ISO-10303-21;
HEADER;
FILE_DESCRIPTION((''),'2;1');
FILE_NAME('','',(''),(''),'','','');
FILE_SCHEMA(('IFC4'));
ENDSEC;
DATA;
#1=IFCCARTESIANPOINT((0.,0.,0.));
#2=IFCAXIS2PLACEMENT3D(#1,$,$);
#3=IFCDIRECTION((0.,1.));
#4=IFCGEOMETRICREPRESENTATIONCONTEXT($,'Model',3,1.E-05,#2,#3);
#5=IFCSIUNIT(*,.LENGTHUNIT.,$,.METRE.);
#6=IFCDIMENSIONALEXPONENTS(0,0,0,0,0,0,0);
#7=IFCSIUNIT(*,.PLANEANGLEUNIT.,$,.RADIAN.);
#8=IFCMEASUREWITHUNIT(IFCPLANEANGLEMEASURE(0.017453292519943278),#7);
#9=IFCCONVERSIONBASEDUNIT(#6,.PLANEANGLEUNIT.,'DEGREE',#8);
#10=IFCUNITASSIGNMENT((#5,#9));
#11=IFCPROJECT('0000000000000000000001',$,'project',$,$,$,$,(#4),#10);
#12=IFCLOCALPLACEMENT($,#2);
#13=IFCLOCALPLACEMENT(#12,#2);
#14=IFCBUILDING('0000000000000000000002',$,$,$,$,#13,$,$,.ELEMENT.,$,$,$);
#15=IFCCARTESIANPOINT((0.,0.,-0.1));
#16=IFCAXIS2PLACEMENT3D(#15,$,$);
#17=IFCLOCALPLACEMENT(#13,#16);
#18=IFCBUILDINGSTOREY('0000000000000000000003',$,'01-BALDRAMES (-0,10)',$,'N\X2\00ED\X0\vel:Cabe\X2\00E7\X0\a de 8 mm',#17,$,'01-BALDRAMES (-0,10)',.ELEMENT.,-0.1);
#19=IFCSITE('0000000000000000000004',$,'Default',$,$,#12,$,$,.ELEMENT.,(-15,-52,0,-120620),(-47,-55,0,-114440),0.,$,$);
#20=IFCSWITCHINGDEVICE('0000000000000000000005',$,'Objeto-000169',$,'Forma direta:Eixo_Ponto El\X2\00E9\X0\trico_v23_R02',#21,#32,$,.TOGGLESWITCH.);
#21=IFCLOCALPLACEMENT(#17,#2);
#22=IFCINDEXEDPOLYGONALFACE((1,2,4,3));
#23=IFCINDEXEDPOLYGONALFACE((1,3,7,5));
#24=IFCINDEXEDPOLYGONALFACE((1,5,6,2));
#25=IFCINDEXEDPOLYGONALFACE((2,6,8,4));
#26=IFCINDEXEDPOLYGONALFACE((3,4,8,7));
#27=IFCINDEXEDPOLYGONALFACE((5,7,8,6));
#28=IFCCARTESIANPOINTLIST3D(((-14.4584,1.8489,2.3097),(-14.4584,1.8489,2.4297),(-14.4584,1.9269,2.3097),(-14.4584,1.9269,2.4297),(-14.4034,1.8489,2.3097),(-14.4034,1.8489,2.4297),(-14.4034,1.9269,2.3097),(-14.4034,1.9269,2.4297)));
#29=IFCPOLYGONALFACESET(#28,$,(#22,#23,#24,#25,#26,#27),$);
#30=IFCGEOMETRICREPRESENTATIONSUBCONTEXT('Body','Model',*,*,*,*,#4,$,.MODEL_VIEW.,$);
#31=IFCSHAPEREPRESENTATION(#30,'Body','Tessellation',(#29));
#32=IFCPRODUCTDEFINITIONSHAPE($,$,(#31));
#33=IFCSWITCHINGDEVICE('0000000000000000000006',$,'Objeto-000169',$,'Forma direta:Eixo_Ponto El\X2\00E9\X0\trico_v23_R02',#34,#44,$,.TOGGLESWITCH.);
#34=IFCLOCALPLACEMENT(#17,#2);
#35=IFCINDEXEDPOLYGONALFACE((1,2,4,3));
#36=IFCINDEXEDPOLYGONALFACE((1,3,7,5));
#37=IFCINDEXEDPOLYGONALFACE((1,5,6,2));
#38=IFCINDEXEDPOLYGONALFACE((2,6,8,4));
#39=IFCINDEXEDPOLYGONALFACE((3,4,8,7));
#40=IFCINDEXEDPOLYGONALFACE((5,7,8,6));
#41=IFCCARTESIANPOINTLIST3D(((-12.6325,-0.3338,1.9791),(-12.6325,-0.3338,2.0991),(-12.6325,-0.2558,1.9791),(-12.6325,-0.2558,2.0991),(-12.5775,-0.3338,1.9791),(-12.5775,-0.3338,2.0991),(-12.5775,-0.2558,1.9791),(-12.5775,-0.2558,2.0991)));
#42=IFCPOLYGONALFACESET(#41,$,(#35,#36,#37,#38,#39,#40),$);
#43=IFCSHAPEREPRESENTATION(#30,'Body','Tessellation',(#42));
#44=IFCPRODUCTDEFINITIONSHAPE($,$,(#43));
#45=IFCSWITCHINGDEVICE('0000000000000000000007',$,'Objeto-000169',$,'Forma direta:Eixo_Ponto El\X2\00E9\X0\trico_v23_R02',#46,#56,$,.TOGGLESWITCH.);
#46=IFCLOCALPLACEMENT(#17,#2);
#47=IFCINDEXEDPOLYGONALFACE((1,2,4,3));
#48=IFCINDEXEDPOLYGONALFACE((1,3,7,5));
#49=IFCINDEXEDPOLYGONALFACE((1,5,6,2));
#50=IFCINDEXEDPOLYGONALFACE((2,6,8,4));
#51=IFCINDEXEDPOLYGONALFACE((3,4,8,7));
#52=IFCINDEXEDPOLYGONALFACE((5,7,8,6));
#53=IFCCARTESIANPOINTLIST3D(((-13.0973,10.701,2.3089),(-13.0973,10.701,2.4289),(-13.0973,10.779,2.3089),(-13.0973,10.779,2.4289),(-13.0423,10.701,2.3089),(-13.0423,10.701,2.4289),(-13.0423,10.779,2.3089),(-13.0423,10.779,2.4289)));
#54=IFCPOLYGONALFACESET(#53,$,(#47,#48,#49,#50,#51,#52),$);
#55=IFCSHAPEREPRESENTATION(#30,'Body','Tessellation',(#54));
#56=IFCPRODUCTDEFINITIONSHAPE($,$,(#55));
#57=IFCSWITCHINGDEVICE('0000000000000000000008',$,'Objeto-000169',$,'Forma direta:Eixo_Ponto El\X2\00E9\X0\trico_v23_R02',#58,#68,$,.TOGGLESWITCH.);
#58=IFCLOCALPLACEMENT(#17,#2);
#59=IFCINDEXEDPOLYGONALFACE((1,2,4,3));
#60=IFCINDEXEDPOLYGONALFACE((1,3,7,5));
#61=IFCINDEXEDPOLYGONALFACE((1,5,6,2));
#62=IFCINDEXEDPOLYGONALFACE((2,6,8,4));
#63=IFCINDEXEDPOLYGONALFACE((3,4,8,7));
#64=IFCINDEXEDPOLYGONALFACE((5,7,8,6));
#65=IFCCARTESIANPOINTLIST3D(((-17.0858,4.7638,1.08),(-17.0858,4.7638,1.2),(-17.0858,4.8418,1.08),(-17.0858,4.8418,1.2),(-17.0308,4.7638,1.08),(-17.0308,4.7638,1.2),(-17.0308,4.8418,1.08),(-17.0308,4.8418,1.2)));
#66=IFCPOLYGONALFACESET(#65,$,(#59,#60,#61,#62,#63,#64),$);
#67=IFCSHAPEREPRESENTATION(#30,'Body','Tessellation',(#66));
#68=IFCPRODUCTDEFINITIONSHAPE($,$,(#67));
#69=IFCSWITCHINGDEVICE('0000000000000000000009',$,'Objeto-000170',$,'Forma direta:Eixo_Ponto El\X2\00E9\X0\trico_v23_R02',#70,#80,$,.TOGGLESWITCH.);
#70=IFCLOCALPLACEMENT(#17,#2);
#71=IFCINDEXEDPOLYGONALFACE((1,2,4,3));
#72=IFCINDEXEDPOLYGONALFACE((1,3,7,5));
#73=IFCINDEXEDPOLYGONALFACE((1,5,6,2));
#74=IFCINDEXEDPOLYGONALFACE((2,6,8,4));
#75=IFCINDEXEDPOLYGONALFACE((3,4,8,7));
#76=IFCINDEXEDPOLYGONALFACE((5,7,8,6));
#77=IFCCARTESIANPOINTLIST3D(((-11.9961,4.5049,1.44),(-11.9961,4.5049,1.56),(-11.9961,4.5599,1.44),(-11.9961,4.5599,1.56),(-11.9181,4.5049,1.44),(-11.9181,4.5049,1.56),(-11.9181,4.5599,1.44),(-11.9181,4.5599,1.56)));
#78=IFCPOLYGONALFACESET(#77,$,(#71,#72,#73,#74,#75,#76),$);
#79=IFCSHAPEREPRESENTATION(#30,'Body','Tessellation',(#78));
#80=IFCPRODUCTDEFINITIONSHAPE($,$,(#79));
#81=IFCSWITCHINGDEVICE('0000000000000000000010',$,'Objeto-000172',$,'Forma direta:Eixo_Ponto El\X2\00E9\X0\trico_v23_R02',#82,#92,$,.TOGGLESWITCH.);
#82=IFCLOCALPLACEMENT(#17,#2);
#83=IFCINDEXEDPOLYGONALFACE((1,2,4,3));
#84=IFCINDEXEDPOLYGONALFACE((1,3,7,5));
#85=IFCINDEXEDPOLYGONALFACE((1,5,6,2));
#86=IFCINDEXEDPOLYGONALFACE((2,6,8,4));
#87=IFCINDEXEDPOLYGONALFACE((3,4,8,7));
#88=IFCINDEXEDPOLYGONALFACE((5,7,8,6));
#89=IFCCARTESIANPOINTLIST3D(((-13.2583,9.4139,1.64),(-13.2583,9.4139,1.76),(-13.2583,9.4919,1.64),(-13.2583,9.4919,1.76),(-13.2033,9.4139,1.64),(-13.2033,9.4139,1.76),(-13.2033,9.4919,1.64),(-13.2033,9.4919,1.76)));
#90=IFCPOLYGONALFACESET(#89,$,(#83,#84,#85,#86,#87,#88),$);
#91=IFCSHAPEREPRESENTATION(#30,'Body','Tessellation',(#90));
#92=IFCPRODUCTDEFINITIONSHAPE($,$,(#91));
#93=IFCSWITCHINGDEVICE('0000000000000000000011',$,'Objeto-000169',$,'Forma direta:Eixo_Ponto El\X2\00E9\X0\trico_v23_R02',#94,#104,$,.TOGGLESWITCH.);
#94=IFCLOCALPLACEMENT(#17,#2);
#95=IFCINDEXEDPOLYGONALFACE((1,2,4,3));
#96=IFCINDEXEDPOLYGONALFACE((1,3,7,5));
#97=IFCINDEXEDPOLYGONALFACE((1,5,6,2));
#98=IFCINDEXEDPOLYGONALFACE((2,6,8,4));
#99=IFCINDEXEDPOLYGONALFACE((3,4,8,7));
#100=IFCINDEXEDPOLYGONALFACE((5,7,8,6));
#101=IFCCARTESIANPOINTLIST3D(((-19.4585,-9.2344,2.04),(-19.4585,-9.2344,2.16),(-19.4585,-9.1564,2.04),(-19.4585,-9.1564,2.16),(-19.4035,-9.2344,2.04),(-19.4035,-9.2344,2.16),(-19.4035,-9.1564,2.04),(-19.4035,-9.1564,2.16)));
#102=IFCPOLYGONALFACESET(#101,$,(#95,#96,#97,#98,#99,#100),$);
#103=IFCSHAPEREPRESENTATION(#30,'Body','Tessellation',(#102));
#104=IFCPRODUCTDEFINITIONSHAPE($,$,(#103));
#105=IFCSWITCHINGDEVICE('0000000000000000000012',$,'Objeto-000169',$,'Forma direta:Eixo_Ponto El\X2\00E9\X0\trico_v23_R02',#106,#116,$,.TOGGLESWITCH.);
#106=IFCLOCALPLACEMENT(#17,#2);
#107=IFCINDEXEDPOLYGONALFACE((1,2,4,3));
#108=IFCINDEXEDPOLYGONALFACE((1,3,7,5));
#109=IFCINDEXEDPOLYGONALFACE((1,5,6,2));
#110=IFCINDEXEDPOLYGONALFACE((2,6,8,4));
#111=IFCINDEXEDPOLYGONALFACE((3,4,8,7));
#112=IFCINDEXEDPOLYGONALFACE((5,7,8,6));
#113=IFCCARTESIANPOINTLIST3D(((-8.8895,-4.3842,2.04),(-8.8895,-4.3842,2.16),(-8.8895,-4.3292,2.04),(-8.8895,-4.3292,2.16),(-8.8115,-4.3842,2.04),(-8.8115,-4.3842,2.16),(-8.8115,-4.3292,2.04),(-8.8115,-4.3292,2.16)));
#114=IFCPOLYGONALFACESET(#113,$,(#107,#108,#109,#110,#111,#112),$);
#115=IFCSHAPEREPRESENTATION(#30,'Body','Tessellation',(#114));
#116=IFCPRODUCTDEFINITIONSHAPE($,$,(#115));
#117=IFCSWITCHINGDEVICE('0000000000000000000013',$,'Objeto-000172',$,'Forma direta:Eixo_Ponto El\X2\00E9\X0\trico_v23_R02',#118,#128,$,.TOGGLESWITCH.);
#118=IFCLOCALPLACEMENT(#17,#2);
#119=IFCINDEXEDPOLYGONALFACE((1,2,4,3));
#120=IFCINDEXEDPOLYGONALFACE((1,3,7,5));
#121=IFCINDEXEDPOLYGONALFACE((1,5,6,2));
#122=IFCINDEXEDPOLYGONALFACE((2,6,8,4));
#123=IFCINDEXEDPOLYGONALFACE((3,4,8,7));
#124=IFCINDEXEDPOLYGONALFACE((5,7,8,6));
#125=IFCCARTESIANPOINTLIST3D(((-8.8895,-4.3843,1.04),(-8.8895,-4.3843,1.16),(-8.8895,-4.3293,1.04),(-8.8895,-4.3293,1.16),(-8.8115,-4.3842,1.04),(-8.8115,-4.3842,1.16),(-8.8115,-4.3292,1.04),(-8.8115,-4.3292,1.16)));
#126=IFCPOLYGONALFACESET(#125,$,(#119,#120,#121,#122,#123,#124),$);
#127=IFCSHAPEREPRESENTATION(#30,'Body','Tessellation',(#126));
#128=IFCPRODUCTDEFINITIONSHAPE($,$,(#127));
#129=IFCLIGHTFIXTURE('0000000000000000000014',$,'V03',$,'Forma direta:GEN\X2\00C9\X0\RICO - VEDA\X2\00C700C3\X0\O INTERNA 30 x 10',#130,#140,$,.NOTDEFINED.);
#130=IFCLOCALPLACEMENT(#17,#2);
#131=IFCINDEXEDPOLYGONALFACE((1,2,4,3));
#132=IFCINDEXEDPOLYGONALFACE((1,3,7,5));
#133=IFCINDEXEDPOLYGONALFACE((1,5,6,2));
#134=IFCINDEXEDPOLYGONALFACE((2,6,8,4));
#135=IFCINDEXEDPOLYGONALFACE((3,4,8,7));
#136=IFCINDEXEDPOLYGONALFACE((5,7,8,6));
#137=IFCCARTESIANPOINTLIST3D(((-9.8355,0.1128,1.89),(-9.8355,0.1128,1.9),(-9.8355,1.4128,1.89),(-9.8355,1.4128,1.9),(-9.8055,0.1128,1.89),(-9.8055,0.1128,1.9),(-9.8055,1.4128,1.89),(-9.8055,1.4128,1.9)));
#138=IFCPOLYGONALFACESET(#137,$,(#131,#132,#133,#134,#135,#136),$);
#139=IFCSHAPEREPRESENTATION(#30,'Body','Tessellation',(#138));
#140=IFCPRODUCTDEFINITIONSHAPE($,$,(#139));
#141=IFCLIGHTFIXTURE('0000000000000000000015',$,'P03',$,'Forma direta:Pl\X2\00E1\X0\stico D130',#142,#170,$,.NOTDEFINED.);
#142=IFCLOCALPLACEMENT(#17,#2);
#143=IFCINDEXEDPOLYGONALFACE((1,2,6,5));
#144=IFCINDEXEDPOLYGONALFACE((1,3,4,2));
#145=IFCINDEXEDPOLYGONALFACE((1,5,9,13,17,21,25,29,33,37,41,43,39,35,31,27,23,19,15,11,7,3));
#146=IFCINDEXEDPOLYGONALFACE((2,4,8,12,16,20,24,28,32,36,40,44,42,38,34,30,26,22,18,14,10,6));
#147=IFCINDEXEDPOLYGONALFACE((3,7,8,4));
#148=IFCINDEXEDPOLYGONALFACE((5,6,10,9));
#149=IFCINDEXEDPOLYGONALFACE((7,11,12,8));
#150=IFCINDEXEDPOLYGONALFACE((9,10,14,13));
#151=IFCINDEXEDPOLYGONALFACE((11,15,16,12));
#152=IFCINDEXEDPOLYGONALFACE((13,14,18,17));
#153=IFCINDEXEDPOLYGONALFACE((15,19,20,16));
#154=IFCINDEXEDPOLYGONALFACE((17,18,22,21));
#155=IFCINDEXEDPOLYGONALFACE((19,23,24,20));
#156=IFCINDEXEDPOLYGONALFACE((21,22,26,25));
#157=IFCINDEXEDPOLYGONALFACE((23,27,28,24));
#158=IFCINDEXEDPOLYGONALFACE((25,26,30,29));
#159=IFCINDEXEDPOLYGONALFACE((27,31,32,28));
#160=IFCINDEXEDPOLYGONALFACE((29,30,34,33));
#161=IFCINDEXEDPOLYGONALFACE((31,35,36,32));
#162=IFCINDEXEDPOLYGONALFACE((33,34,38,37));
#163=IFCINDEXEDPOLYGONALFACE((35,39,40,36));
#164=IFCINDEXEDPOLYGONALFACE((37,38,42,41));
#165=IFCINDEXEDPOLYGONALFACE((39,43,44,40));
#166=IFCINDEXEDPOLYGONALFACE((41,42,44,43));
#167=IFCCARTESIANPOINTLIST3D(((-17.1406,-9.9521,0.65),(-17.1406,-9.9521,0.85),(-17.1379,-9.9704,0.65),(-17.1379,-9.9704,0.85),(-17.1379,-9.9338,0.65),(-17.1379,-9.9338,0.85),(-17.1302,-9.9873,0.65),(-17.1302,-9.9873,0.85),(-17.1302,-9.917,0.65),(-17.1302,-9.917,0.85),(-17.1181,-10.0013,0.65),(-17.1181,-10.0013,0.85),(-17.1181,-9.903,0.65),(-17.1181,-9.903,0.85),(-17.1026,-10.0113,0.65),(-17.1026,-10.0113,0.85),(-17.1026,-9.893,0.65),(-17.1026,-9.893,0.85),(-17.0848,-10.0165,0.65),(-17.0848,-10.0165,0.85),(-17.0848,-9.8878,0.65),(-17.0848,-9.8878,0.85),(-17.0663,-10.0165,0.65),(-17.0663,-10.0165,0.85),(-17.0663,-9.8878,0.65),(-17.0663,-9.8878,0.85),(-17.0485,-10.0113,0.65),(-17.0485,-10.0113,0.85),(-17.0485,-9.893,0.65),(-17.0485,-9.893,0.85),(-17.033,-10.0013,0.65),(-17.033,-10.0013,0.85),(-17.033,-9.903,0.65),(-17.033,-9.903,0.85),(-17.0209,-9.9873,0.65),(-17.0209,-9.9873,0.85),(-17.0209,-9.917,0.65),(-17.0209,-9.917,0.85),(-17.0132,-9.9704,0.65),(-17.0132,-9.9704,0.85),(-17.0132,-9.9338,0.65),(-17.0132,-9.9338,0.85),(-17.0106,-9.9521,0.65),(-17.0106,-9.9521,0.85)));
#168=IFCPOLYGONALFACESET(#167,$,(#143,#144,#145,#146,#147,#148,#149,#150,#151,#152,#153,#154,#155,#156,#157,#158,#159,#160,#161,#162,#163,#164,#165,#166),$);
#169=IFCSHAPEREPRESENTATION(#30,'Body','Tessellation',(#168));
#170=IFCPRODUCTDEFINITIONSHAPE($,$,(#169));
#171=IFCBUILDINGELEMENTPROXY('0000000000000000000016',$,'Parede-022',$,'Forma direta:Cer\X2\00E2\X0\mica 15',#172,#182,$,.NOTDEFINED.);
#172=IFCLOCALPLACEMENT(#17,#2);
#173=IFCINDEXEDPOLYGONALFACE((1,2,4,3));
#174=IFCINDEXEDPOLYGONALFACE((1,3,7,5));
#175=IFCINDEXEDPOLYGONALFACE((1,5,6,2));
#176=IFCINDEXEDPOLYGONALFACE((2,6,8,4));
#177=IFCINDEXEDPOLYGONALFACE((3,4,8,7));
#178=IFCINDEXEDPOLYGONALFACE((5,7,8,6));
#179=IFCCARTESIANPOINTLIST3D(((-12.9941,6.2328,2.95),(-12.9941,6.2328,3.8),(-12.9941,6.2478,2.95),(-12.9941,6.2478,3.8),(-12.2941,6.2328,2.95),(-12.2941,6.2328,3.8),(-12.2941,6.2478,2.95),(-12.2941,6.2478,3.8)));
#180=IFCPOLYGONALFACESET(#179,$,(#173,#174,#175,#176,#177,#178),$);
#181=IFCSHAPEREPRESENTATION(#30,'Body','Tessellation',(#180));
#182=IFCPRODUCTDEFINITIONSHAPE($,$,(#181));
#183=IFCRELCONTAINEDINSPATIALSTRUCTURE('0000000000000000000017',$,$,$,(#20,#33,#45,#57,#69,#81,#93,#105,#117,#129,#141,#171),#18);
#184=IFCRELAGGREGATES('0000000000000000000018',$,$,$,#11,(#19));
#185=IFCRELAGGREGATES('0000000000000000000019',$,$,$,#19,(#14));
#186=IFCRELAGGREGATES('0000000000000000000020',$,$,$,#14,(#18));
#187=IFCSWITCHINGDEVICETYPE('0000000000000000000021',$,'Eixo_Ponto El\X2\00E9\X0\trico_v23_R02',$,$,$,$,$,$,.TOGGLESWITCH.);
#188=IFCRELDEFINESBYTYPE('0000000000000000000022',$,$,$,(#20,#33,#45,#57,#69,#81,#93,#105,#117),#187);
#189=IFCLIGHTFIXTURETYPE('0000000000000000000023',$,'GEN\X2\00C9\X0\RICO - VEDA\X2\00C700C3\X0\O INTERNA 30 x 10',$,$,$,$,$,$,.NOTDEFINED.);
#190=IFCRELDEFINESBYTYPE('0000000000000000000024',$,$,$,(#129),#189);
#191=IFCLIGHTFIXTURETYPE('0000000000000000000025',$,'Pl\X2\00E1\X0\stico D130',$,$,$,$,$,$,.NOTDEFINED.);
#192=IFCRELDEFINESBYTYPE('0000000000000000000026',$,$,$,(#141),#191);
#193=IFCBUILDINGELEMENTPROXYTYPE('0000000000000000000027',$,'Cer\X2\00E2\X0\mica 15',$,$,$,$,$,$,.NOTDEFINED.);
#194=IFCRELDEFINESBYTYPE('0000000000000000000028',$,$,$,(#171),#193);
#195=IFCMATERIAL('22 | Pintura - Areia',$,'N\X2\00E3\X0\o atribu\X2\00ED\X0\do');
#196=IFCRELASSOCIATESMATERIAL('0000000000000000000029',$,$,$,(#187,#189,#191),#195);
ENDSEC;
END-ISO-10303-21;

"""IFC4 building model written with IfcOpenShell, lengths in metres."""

from ifc_helpers import new_model, entity, si_unit, converted_unit, direction, frame, origin, place, context, subcontext, project, spatial, arc, indexed_curve, outline, extrude, material, type_object, element, save


model = new_model("IFC4")

# Units and contexts
model_context = context("Model", 3, precision=1e-05, world=origin(), true_north=direction((0.0, 1.0)))
body_context = subcontext(model_context, "Body", "Model", "MODEL_VIEW")
ifc_project = project(units=[si_unit("LENGTHUNIT", "METRE"), converted_unit("PLANEANGLEUNIT", "DEGREE", entity("IfcPlaneAngleMeasure", 0.017453292519943278), si_unit("PLANEANGLEUNIT", "RADIAN"), dimensions=[0, 0, 0, 0, 0, 0, 0])], contexts=[model_context])

# Site, building, storey
site_placement = place(None, origin())
site = spatial("IfcSite", under=ifc_project, at=site_placement, Name="Default", CompositionType="ELEMENT", RefLatitude=(-15, -52, 0, -120620), RefLongitude=(-47, -55, 0, -114440), RefElevation=0.0)
building_placement = place(site_placement, origin())
building = spatial("IfcBuilding", under=site, at=building_placement, CompositionType="ELEMENT")
storey_placement = place(building_placement, frame((0.0, 0.0, -0.1)))
storey = spatial("IfcBuildingStorey", under=building, at=storey_placement, Name="01-BALDRAMES (-0,10)", ObjectType="Nível:Cabeça de 8 mm", LongName="01-BALDRAMES (-0,10)", CompositionType="ELEMENT", Elevation=-0.1)

# Switching devices
ifc_material_1 = material(Name="22 | Pintura - Areia", Category="Não atribuído")
switching_device_type = type_object("IfcSwitchingDeviceType", Name="Eixo_Ponto Elétrico_v23_R02", PredefinedType="TOGGLESWITCH", material=ifc_material_1)
switching_device_1_placement = place(storey_placement, origin())
element("IfcSwitchingDevice", 1, at=switching_device_1_placement, inside=storey, type_object=switching_device_type, Name="Objeto-000169", ObjectType="Forma direta:Eixo_Ponto Elétrico_v23_R02", PredefinedType="TOGGLESWITCH", context=body_context, shape_type="SweptSolid", body=[
    extrude(outline(indexed_curve([(-0.0275, -0.039), (0.0275, -0.039), (0.0275, 0.039), (-0.0275, 0.039), (-0.0275, -0.039)], self_intersect=False)), frame((-14.4309, 1.8879, 2.3097)), (0.0, 0.0, 1.0), 0.12),
])
switching_device_2_placement = place(storey_placement, origin())
element("IfcSwitchingDevice", 2, at=switching_device_2_placement, inside=storey, type_object=switching_device_type, Name="Objeto-000169", ObjectType="Forma direta:Eixo_Ponto Elétrico_v23_R02", PredefinedType="TOGGLESWITCH", context=body_context, shape_type="SweptSolid", body=[
    extrude(outline(indexed_curve([(-0.0275, -0.039), (0.0275, -0.039), (0.0275, 0.039), (-0.0275, 0.039), (-0.0275, -0.039)], self_intersect=False)), frame((-12.605, -0.2948, 1.9791), z_axis=(0.0, 0.0, 1.0), x_axis=(-1.0, 0.000011, 0.0)), (0.0, 0.0, 1.0), 0.12),
])
switching_device_3_placement = place(storey_placement, origin())
element("IfcSwitchingDevice", 3, at=switching_device_3_placement, inside=storey, type_object=switching_device_type, Name="Objeto-000169", ObjectType="Forma direta:Eixo_Ponto Elétrico_v23_R02", PredefinedType="TOGGLESWITCH", context=body_context, shape_type="SweptSolid", body=[
    extrude(outline(indexed_curve([(-0.0275, -0.039), (0.0275, -0.039), (0.0275, 0.039), (-0.0275, 0.039), (-0.0275, -0.039)], self_intersect=False)), frame((-13.0698, 10.74, 2.3089), z_axis=(0.0, 0.0, 1.0), x_axis=(-1.0, 0.000013, 0.0)), (0.0, 0.0, 1.0), 0.12),
])
switching_device_4_placement = place(storey_placement, origin())
element("IfcSwitchingDevice", 4, at=switching_device_4_placement, inside=storey, type_object=switching_device_type, Name="Objeto-000169", ObjectType="Forma direta:Eixo_Ponto Elétrico_v23_R02", PredefinedType="TOGGLESWITCH", context=body_context, shape_type="SweptSolid", body=[
    extrude(outline(indexed_curve([(-0.0275, -0.039), (0.0275, -0.039), (0.0275, 0.039), (-0.0275, 0.039), (-0.0275, -0.039)], self_intersect=False)), frame((-17.0583, 4.8028, 1.08), z_axis=(0.0, 0.0, 1.0), x_axis=(-1.0, 0.000013, 0.0)), (0.0, 0.0, 1.0), 0.12),
])
switching_device_5_placement = place(storey_placement, origin())
element("IfcSwitchingDevice", 5, at=switching_device_5_placement, inside=storey, type_object=switching_device_type, Name="Objeto-000170", ObjectType="Forma direta:Eixo_Ponto Elétrico_v23_R02", PredefinedType="TOGGLESWITCH", context=body_context, shape_type="SweptSolid", body=[
    extrude(outline(indexed_curve([(-0.0275, -0.039), (0.0275, -0.039), (0.0275, 0.039), (-0.0275, 0.039), (-0.0275, -0.039)], self_intersect=False)), frame((-11.9571, 4.5324, 1.44), z_axis=(0.0, 0.0, 1.0), x_axis=(0.000013, 1.0, 0.0)), (0.0, 0.0, 1.0), 0.12),
])
switching_device_6_placement = place(storey_placement, origin())
element("IfcSwitchingDevice", 6, at=switching_device_6_placement, inside=storey, type_object=switching_device_type, Name="Objeto-000172", ObjectType="Forma direta:Eixo_Ponto Elétrico_v23_R02", PredefinedType="TOGGLESWITCH", context=body_context, shape_type="SweptSolid", body=[
    extrude(outline(indexed_curve([(-0.0275, -0.039), (0.0275, -0.039), (0.0275, 0.039), (-0.0275, 0.039), (-0.0275, -0.039)], self_intersect=False)), frame((-13.2308, 9.4529, 1.64)), (0.0, 0.0, 1.0), 0.12),
])
switching_device_7_placement = place(storey_placement, origin())
element("IfcSwitchingDevice", 7, at=switching_device_7_placement, inside=storey, type_object=switching_device_type, Name="Objeto-000169", ObjectType="Forma direta:Eixo_Ponto Elétrico_v23_R02", PredefinedType="TOGGLESWITCH", context=body_context, shape_type="SweptSolid", body=[
    extrude(outline(indexed_curve([(-0.0275, -0.039), (0.0275, -0.039), (0.0275, 0.039), (-0.0275, 0.039), (-0.0275, -0.039)], self_intersect=False)), frame((-19.431, -9.1954, 2.04)), (0.0, 0.0, 1.0), 0.12),
])
switching_device_8_placement = place(storey_placement, origin())
element("IfcSwitchingDevice", 8, at=switching_device_8_placement, inside=storey, type_object=switching_device_type, Name="Objeto-000169", ObjectType="Forma direta:Eixo_Ponto Elétrico_v23_R02", PredefinedType="TOGGLESWITCH", context=body_context, shape_type="SweptSolid", body=[
    extrude(outline(indexed_curve([(-0.0275, -0.039), (0.0275, -0.039), (0.0275, 0.039), (-0.0275, 0.039), (-0.0275, -0.039)], self_intersect=False)), frame((-8.8505, -4.3567, 2.04), z_axis=(0.0, 0.0, 1.0), x_axis=(-0.000011, -1.0, 0.0)), (0.0, 0.0, 1.0), 0.12),
])
switching_device_9_placement = place(storey_placement, origin())
element("IfcSwitchingDevice", 9, at=switching_device_9_placement, inside=storey, type_object=switching_device_type, Name="Objeto-000172", ObjectType="Forma direta:Eixo_Ponto Elétrico_v23_R02", PredefinedType="TOGGLESWITCH", context=body_context, shape_type="SweptSolid", body=[
    extrude(outline(indexed_curve([(-0.0275, -0.039), (0.0275, -0.039), (0.0275, 0.039), (-0.0275, 0.039), (-0.0275, -0.039)], self_intersect=False)), frame((-8.8505, -4.3567, 1.04), z_axis=(0.0, 0.0, 1.0), x_axis=(0.000186, -1.0, 0.0)), (0.0, 0.0, 1.0), 0.12),
])

# Light fixtures
light_fixture_type_1 = type_object("IfcLightFixtureType", Name="GENÉRICO - VEDAÇÃO INTERNA 30 x 10", PredefinedType="NOTDEFINED", material=ifc_material_1)
light_fixture_1_placement = place(storey_placement, origin())
element("IfcLightFixture", 10, at=light_fixture_1_placement, inside=storey, type_object=light_fixture_type_1, Name="V03", ObjectType="Forma direta:GENÉRICO - VEDAÇÃO INTERNA 30 x 10", PredefinedType="NOTDEFINED", context=body_context, shape_type="SweptSolid", body=[
    extrude(outline(indexed_curve([(-0.65, -0.015), (0.65, -0.015), (0.65, 0.015), (-0.65, 0.015), (-0.65, -0.015)], self_intersect=False)), frame((-9.8205, 0.7628, 1.89), z_axis=(0.0, 0.0, 1.0), x_axis=(-0.000006, 1.0, 0.0)), (0.0, 0.0, 1.0), 0.01),
])
light_fixture_type_2 = type_object("IfcLightFixtureType", Name="Plástico D130", PredefinedType="NOTDEFINED", material=ifc_material_1)
light_fixture_2_placement = place(storey_placement, origin())
element("IfcLightFixture", 11, at=light_fixture_2_placement, inside=storey, type_object=light_fixture_type_2, Name="P03", ObjectType="Forma direta:Plástico D130", PredefinedType="NOTDEFINED", context=body_context, shape_type="SweptSolid", body=[
    extrude(outline(indexed_curve([(0.065, 0.0), (0.0, 0.065), (-0.065, 0.0), (0.0, -0.065)], segments=[arc(1, 2, 3), arc(3, 4, 1)], self_intersect=False)), frame((-17.0756, -9.9521, 0.65)), (0.0, 0.0, 1.0), 0.2),
])

# Building element proxy
building_element_proxy_type_1 = type_object("IfcBuildingElementProxyType", Name="Cerâmica 15", PredefinedType="NOTDEFINED")
proxy_1_placement = place(storey_placement, origin())
element("IfcBuildingElementProxy", 12, at=proxy_1_placement, inside=storey, type_object=building_element_proxy_type_1, Name="Parede-022", ObjectType="Forma direta:Cerâmica 15", PredefinedType="NOTDEFINED", context=body_context, shape_type="SweptSolid", body=[
    extrude(outline(indexed_curve([(-0.0075, -0.35), (0.0075, -0.35), (0.0075, 0.35), (-0.0075, 0.35), (-0.0075, -0.35)], self_intersect=False)), frame((-12.6441, 6.2403, 2.95), z_axis=(0.0, 0.0, 1.0), x_axis=(-0.000013, -1.0, 0.0)), (0.0, 0.0, 1.0), 0.85),
])

save(model, "model.ifc")
